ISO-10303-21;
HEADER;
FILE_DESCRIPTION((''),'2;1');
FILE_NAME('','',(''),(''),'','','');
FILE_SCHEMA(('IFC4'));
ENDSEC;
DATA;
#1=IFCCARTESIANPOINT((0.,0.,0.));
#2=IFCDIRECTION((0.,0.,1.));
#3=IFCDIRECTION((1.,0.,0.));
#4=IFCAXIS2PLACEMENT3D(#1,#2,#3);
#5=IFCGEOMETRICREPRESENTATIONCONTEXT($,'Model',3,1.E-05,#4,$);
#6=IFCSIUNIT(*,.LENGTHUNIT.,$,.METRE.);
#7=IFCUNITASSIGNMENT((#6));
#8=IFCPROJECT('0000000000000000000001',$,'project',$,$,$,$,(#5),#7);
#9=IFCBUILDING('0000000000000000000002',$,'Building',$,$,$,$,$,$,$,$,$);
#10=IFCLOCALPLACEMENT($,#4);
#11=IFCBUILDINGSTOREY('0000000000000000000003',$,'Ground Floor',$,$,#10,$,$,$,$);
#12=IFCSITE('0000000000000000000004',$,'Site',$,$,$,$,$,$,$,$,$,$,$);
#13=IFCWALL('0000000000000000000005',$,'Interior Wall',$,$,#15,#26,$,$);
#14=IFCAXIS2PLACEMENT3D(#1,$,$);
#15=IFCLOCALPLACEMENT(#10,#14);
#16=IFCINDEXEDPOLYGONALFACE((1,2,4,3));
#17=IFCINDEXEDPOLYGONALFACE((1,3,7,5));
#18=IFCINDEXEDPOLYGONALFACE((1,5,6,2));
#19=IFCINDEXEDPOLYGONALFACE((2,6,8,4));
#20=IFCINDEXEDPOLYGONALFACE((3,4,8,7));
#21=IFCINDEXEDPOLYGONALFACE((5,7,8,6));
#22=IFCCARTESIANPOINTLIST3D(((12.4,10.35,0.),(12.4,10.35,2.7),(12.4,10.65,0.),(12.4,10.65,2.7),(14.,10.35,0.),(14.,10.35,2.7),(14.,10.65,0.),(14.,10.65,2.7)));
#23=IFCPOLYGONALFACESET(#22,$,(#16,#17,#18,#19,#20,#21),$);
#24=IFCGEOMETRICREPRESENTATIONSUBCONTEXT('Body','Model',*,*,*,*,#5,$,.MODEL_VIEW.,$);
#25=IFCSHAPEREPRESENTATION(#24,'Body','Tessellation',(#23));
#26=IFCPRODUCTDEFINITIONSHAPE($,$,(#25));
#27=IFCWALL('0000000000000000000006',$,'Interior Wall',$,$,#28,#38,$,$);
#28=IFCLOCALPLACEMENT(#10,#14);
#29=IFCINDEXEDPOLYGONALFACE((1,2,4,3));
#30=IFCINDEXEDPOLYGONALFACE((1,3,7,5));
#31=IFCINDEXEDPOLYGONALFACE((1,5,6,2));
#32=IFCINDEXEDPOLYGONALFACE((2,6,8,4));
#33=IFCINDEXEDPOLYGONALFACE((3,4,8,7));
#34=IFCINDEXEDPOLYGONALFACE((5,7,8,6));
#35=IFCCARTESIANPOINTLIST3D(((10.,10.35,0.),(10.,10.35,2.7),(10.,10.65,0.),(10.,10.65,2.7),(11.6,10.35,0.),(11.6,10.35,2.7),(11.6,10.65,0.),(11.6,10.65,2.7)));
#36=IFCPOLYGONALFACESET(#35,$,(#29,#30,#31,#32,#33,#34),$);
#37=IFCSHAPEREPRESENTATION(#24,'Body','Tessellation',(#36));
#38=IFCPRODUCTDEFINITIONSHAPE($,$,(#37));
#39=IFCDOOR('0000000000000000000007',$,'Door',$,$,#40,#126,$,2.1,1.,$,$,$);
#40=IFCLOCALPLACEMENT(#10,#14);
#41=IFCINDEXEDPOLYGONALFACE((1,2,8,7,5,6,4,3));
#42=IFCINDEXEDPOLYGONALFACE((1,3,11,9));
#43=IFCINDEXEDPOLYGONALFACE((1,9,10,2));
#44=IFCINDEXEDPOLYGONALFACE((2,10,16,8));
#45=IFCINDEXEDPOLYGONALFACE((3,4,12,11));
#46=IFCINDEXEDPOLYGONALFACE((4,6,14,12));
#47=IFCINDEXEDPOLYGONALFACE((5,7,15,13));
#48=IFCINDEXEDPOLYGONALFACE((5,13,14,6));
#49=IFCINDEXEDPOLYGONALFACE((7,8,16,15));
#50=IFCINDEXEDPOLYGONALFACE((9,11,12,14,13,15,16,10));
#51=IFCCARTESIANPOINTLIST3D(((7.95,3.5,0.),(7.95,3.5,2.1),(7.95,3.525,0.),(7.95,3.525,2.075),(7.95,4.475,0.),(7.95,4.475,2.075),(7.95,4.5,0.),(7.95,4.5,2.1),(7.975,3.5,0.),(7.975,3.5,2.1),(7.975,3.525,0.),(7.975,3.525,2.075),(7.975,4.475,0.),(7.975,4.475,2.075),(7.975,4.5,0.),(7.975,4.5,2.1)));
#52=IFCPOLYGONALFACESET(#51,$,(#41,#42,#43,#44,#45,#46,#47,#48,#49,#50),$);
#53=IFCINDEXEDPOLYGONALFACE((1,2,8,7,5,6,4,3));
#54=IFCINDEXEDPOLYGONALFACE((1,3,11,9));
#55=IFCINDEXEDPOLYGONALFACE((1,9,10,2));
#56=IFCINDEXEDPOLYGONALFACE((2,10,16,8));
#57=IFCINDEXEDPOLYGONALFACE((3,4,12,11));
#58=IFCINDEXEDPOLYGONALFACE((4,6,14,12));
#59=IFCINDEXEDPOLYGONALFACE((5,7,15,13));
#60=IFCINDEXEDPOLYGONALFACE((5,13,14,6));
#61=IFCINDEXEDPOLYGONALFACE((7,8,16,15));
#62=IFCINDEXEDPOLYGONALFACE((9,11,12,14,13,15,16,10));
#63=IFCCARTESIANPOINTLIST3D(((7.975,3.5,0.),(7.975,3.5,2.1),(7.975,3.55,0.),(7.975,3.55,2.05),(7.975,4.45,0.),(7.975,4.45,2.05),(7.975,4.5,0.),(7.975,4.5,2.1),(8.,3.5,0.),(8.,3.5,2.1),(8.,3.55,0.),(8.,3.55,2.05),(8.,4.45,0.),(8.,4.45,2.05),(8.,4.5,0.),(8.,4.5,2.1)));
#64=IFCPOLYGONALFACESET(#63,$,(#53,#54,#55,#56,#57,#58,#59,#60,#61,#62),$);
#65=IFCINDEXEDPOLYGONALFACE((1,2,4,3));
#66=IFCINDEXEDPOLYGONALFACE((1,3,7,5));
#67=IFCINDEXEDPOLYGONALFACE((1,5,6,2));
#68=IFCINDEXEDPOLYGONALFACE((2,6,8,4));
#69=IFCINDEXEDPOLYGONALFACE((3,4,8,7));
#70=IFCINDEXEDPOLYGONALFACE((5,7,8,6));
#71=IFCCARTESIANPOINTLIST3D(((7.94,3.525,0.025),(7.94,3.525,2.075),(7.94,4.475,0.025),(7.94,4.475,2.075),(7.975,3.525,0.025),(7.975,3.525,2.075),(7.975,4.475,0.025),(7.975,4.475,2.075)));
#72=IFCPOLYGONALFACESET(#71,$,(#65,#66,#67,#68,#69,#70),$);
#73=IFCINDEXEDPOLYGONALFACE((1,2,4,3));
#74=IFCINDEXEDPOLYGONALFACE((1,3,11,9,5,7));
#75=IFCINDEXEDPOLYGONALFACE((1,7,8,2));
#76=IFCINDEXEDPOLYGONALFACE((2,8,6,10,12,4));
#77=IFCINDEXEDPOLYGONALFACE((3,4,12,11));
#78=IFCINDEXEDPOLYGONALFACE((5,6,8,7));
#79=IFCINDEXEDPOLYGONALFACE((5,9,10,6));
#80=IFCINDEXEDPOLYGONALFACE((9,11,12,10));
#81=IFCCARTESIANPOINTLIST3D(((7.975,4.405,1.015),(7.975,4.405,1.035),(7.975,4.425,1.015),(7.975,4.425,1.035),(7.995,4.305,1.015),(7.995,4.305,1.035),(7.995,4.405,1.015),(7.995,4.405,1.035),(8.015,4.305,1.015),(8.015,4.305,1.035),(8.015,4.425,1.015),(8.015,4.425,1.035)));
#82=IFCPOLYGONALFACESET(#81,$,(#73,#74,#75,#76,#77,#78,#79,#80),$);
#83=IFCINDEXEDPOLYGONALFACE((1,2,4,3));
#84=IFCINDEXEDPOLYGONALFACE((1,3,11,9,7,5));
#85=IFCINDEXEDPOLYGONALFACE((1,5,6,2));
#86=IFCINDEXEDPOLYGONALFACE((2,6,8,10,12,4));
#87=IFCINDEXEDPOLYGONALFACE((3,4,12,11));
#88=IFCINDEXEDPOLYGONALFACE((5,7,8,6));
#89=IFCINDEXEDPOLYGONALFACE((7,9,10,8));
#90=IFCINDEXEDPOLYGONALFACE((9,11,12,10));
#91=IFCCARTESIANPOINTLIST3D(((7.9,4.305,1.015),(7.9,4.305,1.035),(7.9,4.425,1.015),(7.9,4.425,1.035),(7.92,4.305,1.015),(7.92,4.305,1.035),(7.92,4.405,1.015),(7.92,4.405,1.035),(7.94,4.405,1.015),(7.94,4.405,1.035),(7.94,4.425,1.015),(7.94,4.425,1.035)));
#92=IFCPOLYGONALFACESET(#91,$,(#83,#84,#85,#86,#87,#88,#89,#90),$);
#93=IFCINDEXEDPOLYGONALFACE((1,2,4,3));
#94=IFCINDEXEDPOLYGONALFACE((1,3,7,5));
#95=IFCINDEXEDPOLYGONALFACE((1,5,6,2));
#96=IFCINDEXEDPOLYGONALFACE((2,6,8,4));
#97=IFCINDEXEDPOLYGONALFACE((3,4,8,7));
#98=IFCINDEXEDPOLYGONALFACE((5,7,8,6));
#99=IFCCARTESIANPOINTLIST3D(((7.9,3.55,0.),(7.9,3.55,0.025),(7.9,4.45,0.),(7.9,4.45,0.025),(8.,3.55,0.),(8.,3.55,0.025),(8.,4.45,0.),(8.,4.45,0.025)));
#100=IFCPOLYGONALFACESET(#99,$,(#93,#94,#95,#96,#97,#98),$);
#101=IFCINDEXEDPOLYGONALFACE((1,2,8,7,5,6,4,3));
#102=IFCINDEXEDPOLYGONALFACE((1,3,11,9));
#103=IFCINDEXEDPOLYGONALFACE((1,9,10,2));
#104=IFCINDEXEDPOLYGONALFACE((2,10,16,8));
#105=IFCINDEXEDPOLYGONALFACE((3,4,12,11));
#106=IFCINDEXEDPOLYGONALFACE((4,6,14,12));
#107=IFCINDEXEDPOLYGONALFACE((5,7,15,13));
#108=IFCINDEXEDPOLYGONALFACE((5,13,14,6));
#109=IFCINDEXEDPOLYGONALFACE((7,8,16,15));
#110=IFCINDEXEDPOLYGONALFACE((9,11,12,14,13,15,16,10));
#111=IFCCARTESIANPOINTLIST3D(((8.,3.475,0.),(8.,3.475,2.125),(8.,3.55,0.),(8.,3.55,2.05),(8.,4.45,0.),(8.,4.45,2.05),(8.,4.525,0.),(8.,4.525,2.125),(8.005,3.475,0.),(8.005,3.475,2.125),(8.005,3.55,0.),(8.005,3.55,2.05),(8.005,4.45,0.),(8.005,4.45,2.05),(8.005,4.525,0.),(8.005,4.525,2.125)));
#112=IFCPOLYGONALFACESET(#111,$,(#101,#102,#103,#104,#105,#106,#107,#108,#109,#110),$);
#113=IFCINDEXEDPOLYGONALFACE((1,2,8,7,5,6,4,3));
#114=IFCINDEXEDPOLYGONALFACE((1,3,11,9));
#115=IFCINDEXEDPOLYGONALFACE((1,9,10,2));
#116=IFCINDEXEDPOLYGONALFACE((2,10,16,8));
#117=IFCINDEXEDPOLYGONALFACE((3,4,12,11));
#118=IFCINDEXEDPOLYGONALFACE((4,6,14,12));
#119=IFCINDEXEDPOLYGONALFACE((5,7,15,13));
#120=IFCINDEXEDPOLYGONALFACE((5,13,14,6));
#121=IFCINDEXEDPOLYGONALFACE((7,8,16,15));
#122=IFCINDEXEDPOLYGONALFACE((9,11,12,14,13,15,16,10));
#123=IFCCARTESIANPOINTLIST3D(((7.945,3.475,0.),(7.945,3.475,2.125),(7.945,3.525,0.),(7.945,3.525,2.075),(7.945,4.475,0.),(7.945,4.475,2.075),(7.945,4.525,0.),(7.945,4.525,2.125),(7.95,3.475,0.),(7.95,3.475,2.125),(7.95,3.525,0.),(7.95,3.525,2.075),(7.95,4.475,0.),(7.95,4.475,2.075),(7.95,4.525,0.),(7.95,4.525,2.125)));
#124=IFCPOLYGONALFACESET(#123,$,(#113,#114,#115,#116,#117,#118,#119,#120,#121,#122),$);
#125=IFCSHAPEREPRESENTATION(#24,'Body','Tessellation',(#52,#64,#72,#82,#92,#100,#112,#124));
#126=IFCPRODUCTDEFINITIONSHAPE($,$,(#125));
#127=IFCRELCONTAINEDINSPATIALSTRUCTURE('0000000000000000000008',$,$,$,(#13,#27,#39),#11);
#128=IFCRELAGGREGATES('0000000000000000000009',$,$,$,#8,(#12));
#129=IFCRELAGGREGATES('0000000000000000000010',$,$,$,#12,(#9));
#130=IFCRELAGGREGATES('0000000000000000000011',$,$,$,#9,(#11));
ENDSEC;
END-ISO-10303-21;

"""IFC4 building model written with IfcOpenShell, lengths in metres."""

from ifc_helpers import new_model, si_unit, frame, origin_with_axes, place, context, subcontext, project, spatial, line, indexed_curve, outline, extrude, element, save


model = new_model("IFC4")

# Units and contexts
model_context = context("Model", 3, precision=1e-05, world=origin_with_axes())
body_context = subcontext(model_context, "Body", "Model", "MODEL_VIEW")
ifc_project = project(units=[si_unit("LENGTHUNIT", "METRE")], contexts=[model_context])

# Site, building, storey
site = spatial("IfcSite", under=ifc_project, Name="Site")
building = spatial("IfcBuilding", under=site, Name="Building")
storey_placement = place(None, origin_with_axes())
storey = spatial("IfcBuildingStorey", under=building, at=storey_placement, Name="Ground Floor")

# Walls
for number, where, z_axis, x_axis, name in (
    (1, (14.0, 10.5, 0.0), (0.0, 0.0, 1.0), (-1.0, 0.0, 0.0), "Interior Wall"),
    (2, (11.6, 10.5, 0.0), (0.0, 0.0, 1.0), (-1.0, 0.0, 0.0), "Interior Wall"),
):
    element("IfcWall", number, at=place(storey_placement, frame(where, z_axis=z_axis, x_axis=x_axis)), inside=storey, Name=name, context=body_context, shape_type="SweptSolid", body=[
        extrude(outline(indexed_curve([(0.0, 0.0), (0.0, 0.3), (1.6, 0.3), (1.6, 0.0), (0.0, 0.0)], self_intersect=False)), frame((0.0, -0.15, 0.0), z_axis=(0.0, 0.0, 1.0), x_axis=(1.0, 0.0, 0.0)), (0.0, 0.0, 1.0), 2.7),
    ])

# Door
door_1_placement = place(storey_placement, frame((8.0, 3.5, 0.0), z_axis=(0.0, 0.0, 1.0), x_axis=(0.0, 1.0, 0.0)))
element("IfcDoor", 3, at=door_1_placement, inside=storey, Name="Door", OverallHeight=2.1, OverallWidth=1.0, context=body_context, shape_type="SweptSolid", body=[
    extrude(outline(indexed_curve([(0.0, 0.0), (0.0, 2.1), (1.0, 2.1), (1.0, 0.0), (0.975, 0.0), (0.975, 2.075), (0.025, 2.075), (0.025, 0.0)], segments=[line(1, 2, 3, 4, 5, 6, 7, 8, 1)])), frame((0.0, 0.025, 0.0), z_axis=(0.0, -1.0, 0.0), x_axis=(1.0, 0.0, 0.0)), (0.0, 0.0, -1.0), 0.025),
    extrude(outline(indexed_curve([(0.0, 0.0), (0.0, 2.1), (1.0, 2.1), (1.0, 0.0), (0.95, 0.0), (0.95, 2.05), (0.05, 2.05), (0.05, 0.0)], segments=[line(1, 2, 3, 4, 5, 6, 7, 8, 1)])), frame((0.0, 0.0, 0.0), z_axis=(0.0, -1.0, 0.0), x_axis=(1.0, 0.0, 0.0)), (0.0, 0.0, -1.0), 0.025),
    extrude(outline(indexed_curve([(0.0, 0.0), (0.95, 0.0), (0.95, 0.035), (0.0, 0.035)], segments=[line(1, 2, 3, 4, 1)])), frame((0.025, 0.025, 0.025), z_axis=(0.0, 0.0, 1.0), x_axis=(1.0, 0.0, 0.0)), (0.0, 0.0, 1.0), 2.05),
    extrude(outline(indexed_curve([(0.0, 0.0), (0.0, -0.04), (-0.12, -0.04), (-0.12, -0.02), (-0.02, -0.02), (-0.02, 0.0)], segments=[line(1, 2, 3, 4, 5, 6, 1)])), frame((0.925, 0.025, 1.015), z_axis=(0.0, 0.0, 1.0), x_axis=(1.0, 0.0, 0.0)), (0.0, 0.0, 1.0), 0.02),
    extrude(outline(indexed_curve([(0.0, 0.0), (0.0, 0.04), (-0.12, 0.04), (-0.12, 0.02), (-0.02, 0.02), (-0.02, 0.0)], segments=[line(1, 2, 3, 4, 5, 6, 1)])), frame((0.925, 0.06, 1.015), z_axis=(0.0, 0.0, 1.0), x_axis=(1.0, 0.0, 0.0)), (0.0, 0.0, 1.0), 0.02),
    extrude(outline(indexed_curve([(0.0, 0.0), (0.9, 0.0), (0.9, 0.1), (0.0, 0.1)], segments=[line(1, 2, 3, 4, 1)])), frame((0.05, 0.0, 0.0), z_axis=(0.0, 0.0, 1.0), x_axis=(1.0, 0.0, 0.0)), (0.0, 0.0, 1.0), 0.025),
    extrude(outline(indexed_curve([(0.0, 0.0), (0.0, 2.125), (1.05, 2.125), (1.05, 0.0), (0.975, 0.0), (0.975, 2.05), (0.075, 2.05), (0.075, 0.0)], segments=[line(1, 2, 3, 4, 5, 6, 7, 8, 1)])), frame((-0.025, -0.005, 0.0), z_axis=(0.0, -1.0, 0.0), x_axis=(1.0, 0.0, 0.0)), (0.0, 0.0, -1.0), 0.005),
    extrude(outline(indexed_curve([(0.0, 0.0), (0.0, 2.125), (1.05, 2.125), (1.05, 0.0), (1.0, 0.0), (1.0, 2.075), (0.05, 2.075), (0.05, 0.0)], segments=[line(1, 2, 3, 4, 5, 6, 7, 8, 1)])), frame((-0.025, 0.05, 0.0), z_axis=(0.0, -1.0, 0.0), x_axis=(1.0, 0.0, 0.0)), (0.0, 0.0, -1.0), 0.005),
])

save(model, "model.ifc")
